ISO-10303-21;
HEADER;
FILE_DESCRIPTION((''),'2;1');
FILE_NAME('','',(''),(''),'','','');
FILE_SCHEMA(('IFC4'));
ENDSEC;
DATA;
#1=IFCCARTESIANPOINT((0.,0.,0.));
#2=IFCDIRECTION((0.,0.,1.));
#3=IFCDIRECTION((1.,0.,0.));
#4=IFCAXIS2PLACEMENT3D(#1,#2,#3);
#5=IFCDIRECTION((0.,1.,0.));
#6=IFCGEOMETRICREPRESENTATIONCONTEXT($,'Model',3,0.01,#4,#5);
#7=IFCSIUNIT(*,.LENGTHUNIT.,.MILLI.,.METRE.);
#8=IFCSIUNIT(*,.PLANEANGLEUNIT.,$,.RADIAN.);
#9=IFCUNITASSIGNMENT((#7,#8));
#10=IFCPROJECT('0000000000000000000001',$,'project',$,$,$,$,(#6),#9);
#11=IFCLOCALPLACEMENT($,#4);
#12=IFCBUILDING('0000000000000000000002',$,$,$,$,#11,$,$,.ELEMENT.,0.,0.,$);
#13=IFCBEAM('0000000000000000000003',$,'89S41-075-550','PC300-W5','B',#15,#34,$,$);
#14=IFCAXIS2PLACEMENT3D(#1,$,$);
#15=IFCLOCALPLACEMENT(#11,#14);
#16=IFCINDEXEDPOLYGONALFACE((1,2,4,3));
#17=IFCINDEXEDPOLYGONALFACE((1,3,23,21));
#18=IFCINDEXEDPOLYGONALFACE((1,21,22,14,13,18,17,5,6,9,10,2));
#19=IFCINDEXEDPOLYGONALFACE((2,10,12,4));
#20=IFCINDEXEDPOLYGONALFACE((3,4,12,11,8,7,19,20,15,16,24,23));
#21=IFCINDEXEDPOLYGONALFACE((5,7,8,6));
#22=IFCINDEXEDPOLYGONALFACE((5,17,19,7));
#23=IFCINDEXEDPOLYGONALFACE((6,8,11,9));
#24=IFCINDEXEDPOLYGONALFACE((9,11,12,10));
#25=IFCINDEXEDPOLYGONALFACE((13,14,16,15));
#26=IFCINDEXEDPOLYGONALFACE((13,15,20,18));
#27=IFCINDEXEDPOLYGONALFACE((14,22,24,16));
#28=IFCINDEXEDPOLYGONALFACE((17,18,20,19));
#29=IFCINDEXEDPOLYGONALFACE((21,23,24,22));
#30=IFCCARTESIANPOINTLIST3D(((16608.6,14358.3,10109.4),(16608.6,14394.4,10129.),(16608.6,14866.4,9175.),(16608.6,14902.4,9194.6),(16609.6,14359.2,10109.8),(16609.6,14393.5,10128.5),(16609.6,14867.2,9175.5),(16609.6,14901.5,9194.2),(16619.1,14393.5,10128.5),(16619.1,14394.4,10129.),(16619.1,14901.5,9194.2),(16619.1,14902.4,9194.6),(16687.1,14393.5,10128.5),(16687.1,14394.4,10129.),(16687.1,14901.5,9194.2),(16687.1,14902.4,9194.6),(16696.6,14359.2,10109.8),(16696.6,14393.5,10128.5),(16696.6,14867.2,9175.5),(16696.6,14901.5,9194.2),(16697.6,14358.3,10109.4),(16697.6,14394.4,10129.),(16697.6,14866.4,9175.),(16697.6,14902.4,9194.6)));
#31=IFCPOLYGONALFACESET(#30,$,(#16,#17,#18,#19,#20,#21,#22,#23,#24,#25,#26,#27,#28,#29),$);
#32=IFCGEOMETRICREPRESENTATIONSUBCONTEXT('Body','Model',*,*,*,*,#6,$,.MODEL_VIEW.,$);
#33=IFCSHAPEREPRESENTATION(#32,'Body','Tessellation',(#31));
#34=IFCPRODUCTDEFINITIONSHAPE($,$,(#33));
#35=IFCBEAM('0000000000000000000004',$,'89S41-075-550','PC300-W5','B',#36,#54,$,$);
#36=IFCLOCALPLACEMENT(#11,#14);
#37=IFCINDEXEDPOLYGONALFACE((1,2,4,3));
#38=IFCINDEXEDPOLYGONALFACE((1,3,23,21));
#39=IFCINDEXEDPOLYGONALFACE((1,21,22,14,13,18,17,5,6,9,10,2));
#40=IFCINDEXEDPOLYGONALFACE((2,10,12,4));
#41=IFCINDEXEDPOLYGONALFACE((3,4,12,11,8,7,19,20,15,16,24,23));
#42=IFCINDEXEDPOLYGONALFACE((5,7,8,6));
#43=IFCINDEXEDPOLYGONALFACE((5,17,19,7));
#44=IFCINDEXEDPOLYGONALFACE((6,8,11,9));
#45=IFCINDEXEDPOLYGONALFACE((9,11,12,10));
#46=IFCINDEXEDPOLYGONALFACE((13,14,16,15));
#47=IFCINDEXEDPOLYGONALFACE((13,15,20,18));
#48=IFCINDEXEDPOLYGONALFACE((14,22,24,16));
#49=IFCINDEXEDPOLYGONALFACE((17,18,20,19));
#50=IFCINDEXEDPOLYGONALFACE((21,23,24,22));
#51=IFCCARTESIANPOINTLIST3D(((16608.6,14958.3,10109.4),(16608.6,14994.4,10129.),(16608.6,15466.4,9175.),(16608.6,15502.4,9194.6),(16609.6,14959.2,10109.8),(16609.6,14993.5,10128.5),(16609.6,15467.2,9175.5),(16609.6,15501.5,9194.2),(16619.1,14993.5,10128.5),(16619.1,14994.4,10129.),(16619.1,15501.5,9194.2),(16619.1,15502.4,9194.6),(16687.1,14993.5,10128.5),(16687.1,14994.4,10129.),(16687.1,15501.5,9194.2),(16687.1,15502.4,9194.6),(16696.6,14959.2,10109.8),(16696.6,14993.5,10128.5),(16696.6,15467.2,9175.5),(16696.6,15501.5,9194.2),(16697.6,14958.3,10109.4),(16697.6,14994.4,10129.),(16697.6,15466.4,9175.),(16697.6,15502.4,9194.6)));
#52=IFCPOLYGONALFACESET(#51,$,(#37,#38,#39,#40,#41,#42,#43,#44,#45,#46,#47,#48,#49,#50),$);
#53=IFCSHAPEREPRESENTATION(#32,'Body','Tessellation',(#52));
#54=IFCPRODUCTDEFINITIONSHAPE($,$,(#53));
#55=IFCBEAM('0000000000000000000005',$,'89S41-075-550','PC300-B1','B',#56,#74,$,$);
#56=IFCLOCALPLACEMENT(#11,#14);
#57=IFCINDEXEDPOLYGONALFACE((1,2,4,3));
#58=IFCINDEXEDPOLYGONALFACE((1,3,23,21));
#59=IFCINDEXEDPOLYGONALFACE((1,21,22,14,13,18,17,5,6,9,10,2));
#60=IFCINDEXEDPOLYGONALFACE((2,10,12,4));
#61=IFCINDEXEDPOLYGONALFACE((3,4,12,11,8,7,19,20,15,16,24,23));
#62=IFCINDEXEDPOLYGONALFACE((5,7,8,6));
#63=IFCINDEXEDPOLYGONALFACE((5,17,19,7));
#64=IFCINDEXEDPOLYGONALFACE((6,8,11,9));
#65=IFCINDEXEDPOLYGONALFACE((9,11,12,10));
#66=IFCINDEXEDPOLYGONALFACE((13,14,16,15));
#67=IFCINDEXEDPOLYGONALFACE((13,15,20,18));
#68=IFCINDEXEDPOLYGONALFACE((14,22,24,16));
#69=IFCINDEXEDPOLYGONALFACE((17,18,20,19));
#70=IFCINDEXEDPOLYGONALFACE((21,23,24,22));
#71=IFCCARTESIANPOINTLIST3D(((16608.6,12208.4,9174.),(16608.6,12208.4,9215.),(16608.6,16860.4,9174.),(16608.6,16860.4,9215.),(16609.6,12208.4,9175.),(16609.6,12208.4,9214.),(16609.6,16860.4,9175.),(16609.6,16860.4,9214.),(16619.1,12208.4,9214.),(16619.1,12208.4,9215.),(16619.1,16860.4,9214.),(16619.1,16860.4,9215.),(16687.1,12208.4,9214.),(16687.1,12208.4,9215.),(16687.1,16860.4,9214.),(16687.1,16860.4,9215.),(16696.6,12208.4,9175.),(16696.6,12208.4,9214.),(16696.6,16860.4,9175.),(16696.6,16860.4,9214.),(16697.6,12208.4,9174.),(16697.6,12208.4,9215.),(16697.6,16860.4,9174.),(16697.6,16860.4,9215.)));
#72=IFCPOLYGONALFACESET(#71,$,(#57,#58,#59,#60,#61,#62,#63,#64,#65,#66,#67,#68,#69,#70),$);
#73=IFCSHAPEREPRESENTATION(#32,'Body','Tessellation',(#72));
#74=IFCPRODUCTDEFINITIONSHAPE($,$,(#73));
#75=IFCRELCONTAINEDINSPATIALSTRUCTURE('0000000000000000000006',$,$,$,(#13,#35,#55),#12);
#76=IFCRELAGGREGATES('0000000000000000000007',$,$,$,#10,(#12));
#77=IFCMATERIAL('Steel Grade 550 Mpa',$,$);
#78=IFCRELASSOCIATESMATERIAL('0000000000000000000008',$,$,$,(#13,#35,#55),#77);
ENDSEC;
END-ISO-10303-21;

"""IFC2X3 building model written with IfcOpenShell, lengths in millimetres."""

from ifc_helpers import new_model, si_unit, direction, frame, origin, origin_with_axes, origin_2d_with_axis, place, context, subcontext, project, spatial, c_section, extrude, source, transform, mapped, material, element, save


model = new_model("IFC2X3")

# Units and contexts
model_context = context("Model", 3, precision=0.01, world=origin_with_axes(), true_north=direction((0.0, 1.0, 0.0)))
body_context = subcontext(model_context, "Body", "Model", "MODEL_VIEW")
ifc_project = project(units=[si_unit("LENGTHUNIT", "METRE", prefix="MILLI"), si_unit("PLANEANGLEUNIT", "RADIAN")], contexts=[model_context])

# Building
building_placement = place(None, origin_with_axes())
building = spatial("IfcBuilding", under=ifc_project, at=building_placement, CompositionType="ELEMENT", ElevationOfRefHeight=0.0, ElevationOfTerrain=0.0)

# Shared definitions
ifc_material = material(Name="Steel Grade 550 Mpa")

# Beams
shared_shape_1 = source(origin(), body_context, "Body", "SweptSolid", [
    extrude(c_section(Depth=89.0, Width=41.0, WallThickness=1.0, Girth=10.5, at=origin_2d_with_axis()), origin_with_axes(), (0.0, 0.0, 1.0), 1063.5),
])
beam_1_placement = place(None, frame((16653.1, 14884.4, 9184.8), z_axis=(0.0, -0.477674, 0.878537), x_axis=(0.0, 0.878537, 0.477674)))
element("IfcBeam", 1, at=beam_1_placement, inside=building, material=ifc_material, Name="89S41-075-550", Description="PC300-W5", ObjectType="B", context=body_context, shape_type="MappedRepresentation", body=[
    mapped(shared_shape_1, transform((0.0, 0.0, 0.0), scale=1.0)),
])
shared_shape_2 = source(origin(), body_context, "Body", "SweptSolid", [
    extrude(c_section(Depth=89.0, Width=41.0, WallThickness=1.0, Girth=10.5, at=origin_2d_with_axis()), origin_with_axes(), (0.0, 0.0, 1.0), 1063.5),
])
beam_2_placement = place(None, frame((16653.1, 15484.4, 9184.8), z_axis=(0.0, -0.477674, 0.878537), x_axis=(0.0, 0.878537, 0.477674)))
element("IfcBeam", 2, at=beam_2_placement, inside=building, material=ifc_material, Name="89S41-075-550", Description="PC300-W5", ObjectType="B", context=body_context, shape_type="MappedRepresentation", body=[
    mapped(shared_shape_2, transform((0.0, 0.0, 0.0), scale=1.0)),
])
shared_shape_3 = source(origin(), body_context, "Body", "SweptSolid", [
    extrude(c_section(Depth=89.0, Width=41.0, WallThickness=1.0, Girth=10.5, at=origin_2d_with_axis()), origin_with_axes(), (0.0, 0.0, 1.0), 4652.0),
])
beam_3_placement = place(None, frame((16653.1, 16860.4, 9194.5), z_axis=(0.0, -1.0, 0.0), x_axis=(0.0, 0.0, 1.0)))
element("IfcBeam", 3, at=beam_3_placement, inside=building, material=ifc_material, Name="89S41-075-550", Description="PC300-B1", ObjectType="B", context=body_context, shape_type="MappedRepresentation", body=[
    mapped(shared_shape_3, transform((0.0, 0.0, 0.0), scale=1.0)),
])

save(model, "model.ifc")
